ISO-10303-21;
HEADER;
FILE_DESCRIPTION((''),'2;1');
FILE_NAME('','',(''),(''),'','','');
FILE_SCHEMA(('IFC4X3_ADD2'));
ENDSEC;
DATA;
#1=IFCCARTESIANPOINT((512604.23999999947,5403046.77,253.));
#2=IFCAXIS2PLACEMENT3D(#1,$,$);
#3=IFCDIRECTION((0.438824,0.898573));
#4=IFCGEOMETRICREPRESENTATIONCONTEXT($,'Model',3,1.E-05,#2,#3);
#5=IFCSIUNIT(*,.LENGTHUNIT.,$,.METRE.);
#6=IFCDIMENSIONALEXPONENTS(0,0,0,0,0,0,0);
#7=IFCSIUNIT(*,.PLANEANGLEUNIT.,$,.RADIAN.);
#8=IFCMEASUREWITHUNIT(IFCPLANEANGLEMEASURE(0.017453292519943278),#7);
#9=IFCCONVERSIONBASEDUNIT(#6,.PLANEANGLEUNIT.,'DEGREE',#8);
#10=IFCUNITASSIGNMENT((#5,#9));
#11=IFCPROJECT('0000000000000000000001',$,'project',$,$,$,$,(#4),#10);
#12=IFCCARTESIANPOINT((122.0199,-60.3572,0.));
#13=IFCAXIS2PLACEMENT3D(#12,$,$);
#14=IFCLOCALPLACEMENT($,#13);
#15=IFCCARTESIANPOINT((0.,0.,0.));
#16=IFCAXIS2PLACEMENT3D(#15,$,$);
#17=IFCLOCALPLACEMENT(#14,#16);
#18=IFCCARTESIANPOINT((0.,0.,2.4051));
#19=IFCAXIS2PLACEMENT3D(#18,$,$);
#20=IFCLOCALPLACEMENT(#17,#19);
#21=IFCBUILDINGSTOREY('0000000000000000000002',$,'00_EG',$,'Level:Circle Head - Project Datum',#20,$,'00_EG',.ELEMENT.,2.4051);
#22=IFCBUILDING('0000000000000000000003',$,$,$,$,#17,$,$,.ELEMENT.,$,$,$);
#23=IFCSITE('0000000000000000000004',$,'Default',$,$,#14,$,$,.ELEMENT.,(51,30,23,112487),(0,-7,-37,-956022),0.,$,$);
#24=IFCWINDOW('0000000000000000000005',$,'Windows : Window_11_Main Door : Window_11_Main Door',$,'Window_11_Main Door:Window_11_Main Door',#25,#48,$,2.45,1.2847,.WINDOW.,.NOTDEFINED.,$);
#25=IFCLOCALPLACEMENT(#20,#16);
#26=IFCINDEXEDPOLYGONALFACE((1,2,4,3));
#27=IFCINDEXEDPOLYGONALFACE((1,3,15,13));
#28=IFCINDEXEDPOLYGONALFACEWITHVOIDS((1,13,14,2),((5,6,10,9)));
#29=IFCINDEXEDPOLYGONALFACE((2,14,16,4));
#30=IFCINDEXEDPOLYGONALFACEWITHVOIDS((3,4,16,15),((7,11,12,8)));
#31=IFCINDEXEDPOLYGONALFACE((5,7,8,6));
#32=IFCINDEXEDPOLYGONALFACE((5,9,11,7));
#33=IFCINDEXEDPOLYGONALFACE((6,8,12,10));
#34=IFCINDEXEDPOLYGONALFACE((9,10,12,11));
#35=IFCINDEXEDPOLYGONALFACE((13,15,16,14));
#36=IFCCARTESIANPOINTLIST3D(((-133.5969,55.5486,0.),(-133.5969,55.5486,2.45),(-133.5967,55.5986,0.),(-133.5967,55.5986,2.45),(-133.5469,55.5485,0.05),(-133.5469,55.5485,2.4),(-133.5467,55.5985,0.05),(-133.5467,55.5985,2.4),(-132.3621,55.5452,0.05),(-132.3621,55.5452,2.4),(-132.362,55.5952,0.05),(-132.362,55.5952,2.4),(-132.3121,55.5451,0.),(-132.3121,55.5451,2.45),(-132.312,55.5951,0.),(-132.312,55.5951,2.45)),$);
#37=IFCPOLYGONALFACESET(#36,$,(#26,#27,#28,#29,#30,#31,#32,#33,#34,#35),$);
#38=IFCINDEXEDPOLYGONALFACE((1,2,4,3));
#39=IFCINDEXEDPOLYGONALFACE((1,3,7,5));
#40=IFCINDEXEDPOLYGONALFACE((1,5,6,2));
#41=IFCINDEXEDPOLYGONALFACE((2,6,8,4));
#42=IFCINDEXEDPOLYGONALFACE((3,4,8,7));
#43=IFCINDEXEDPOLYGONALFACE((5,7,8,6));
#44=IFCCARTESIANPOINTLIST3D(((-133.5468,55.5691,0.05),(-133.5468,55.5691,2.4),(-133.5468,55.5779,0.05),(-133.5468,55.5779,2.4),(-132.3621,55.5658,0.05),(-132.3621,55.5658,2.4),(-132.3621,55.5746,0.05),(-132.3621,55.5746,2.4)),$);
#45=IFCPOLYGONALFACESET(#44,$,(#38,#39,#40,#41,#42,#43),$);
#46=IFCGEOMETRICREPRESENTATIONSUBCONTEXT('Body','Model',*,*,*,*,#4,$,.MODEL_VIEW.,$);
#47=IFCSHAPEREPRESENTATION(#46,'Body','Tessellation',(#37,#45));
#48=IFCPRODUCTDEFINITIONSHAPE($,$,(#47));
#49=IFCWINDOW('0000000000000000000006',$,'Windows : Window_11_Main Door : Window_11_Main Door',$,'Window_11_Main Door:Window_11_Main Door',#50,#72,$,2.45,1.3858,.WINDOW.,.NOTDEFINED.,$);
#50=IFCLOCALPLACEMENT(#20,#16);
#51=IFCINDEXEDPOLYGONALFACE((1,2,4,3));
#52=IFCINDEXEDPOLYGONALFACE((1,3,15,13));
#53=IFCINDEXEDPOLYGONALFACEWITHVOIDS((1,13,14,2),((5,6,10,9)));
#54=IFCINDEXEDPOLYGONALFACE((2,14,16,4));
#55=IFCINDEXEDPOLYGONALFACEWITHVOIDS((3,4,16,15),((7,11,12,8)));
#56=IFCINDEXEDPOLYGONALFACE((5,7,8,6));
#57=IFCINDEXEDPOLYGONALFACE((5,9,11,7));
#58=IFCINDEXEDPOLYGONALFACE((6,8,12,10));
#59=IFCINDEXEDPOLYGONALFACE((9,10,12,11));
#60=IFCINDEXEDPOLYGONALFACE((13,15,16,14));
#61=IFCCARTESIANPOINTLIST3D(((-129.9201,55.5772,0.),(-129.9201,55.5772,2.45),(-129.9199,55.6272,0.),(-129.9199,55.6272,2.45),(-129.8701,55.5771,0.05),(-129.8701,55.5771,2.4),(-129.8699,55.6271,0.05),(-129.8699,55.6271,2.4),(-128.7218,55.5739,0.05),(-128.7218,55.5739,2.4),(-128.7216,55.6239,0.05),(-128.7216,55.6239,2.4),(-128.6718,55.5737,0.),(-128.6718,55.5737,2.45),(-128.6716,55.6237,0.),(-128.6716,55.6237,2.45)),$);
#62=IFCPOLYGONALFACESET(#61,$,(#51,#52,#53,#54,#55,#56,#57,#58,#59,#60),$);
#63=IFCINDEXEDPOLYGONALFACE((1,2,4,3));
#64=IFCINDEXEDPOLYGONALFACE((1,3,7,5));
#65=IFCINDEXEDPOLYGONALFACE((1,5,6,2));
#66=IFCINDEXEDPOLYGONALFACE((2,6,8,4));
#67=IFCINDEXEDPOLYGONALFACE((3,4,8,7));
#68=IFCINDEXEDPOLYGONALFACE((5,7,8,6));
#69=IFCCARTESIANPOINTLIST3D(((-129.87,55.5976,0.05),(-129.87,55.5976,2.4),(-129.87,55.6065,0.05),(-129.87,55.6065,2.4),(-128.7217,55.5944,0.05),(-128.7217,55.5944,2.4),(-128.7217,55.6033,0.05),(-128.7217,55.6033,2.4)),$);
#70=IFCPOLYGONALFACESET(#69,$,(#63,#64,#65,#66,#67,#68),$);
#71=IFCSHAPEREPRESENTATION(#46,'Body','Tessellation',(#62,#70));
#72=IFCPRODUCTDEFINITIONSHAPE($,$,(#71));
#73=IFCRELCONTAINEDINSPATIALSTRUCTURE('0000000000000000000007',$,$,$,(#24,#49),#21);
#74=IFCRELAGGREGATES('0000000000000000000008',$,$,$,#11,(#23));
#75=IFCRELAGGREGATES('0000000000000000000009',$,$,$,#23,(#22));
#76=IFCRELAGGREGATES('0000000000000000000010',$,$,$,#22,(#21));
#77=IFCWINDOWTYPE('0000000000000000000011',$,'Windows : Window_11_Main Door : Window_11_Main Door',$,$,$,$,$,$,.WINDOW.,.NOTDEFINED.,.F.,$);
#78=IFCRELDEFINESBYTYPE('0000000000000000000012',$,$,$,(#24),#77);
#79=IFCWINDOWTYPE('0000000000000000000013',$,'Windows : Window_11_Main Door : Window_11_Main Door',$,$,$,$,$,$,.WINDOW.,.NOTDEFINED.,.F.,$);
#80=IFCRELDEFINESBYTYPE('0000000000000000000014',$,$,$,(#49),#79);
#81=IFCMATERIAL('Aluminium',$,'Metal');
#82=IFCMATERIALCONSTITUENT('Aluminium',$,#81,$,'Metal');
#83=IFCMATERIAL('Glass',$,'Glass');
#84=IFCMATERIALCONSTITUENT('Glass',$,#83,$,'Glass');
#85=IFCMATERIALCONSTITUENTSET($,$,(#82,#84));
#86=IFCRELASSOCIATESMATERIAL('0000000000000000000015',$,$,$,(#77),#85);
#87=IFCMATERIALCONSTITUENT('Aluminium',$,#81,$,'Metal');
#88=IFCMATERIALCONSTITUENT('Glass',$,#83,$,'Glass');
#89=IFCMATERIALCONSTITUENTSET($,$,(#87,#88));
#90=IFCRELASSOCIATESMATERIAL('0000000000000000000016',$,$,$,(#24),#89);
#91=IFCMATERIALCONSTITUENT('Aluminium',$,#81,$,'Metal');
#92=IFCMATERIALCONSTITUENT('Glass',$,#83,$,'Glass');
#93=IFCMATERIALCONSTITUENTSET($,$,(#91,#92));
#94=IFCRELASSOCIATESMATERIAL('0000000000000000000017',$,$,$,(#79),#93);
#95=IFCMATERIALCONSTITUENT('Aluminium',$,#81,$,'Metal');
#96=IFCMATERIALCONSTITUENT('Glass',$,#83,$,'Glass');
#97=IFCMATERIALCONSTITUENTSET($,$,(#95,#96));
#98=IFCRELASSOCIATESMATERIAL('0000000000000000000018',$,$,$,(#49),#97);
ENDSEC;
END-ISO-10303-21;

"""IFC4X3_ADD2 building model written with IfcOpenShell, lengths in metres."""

from ifc_helpers import new_model, entity, si_unit, converted_unit, direction, frame, frame_2d, origin, origin_2d_with_axis, place, context, subcontext, project, spatial, polyline, rectangle, outline, extrude, source, transform, mapped, material, constituent, constituent_set, type_object, type_shapes, element, save


model = new_model("IFC4X3_ADD2")

# Units and contexts
model_context = context("Model", 3, precision=1e-05, world=frame((512604.23999999947, 5403046.77, 253.0)), true_north=direction((0.438824, 0.898573)))
body_context = subcontext(model_context, "Body", "Model", "MODEL_VIEW")
ifc_project = project(units=[si_unit("LENGTHUNIT", "METRE"), converted_unit("PLANEANGLEUNIT", "DEGREE", entity("IfcPlaneAngleMeasure", 0.017453292519943278), si_unit("PLANEANGLEUNIT", "RADIAN"), dimensions=[0, 0, 0, 0, 0, 0, 0])], contexts=[model_context])

# Site, building, storey
site_placement = place(None, frame((122.0199, -60.3572, 0.0)))
site = spatial("IfcSite", under=ifc_project, at=site_placement, Name="Default", CompositionType="ELEMENT", RefLatitude=(51, 30, 23, 112487), RefLongitude=(0, -7, -37, -956022), RefElevation=0.0)
building_placement = place(site_placement, origin())
building = spatial("IfcBuilding", under=site, at=building_placement, CompositionType="ELEMENT")
storey_placement = place(building_placement, frame((0.0, 0.0, 2.4051)))
storey = spatial("IfcBuildingStorey", under=building, at=storey_placement, Name="00_EG", ObjectType="Level:Circle Head - Project Datum", LongName="00_EG", CompositionType="ELEMENT", Elevation=2.4051)

# Shared definitions
ifc_material_1 = material(Name="Glass", Category="Glass")

# Windows
ifc_material_2 = material(Name="Aluminium", Category="Metal")
ifc_constituent_1 = constituent(ifc_material_2, Name="Aluminium", Category="Metal")
ifc_constituent_2 = constituent(ifc_material_1, Name="Glass", Category="Glass")
ifc_constituent_set_1 = constituent_set(constituents=[ifc_constituent_1, ifc_constituent_2])
ifc_constituent_3 = constituent(ifc_material_2, Name="Aluminium", Category="Metal")
ifc_constituent_4 = constituent(ifc_material_1, Name="Glass", Category="Glass")
ifc_constituent_set_2 = constituent_set(constituents=[ifc_constituent_3, ifc_constituent_4])
window_type_1 = type_object("IfcWindowType", Name="Windows : Window_11_Main Door : Window_11_Main Door", ParameterTakesPrecedence=False, PartitioningType="NOTDEFINED", PredefinedType="WINDOW", material=ifc_constituent_set_2)
shared_shape_1 = source(origin(), body_context, "Body", "SweptSolid", [
    extrude(outline(polyline([(-0.6424, -1.225), (0.6424, -1.225), (0.6424, 1.225), (-0.6424, 1.225), (-0.6424, -1.225)]), holes=[polyline([(-0.5924, 1.175), (0.5924, 1.175), (0.5924, -1.175), (-0.5924, -1.175), (-0.5924, 1.175)])]), frame((0.6424, -0.263, 1.225), z_axis=(0.0, 1.0, 0.0), x_axis=(1.0, 0.0, 0.0)), (0.0, 0.0, 1.0), 0.05),
    extrude(rectangle(XDim=0.0088, YDim=1.1847, at=origin_2d_with_axis()), frame((0.6424, -0.238, 0.05), z_axis=(0.0, 0.0, 1.0), x_axis=(0.0, 1.0, 0.0)), (0.0, 0.0, 1.0), 2.35),
])
type_shapes(window_type_1, [shared_shape_1])
window_1_placement = place(storey_placement, frame((-133.5961, 55.8117, 0.0), z_axis=(0.0, 0.0, 1.0), x_axis=(0.999996, -0.002787, 0.0)))
element("IfcWindow", 1, at=window_1_placement, inside=storey, type_object=window_type_1, material=ifc_constituent_set_1, Name="Windows : Window_11_Main Door : Window_11_Main Door", ObjectType="Window_11_Main Door:Window_11_Main Door", OverallHeight=2.45, OverallWidth=1.2847, PartitioningType="NOTDEFINED", PredefinedType="WINDOW", context=body_context, shape_type="MappedRepresentation", body=[
    mapped(shared_shape_1, transform((0.0, 0.0, 0.0), scale=1.0)),
])
ifc_constituent_5 = constituent(ifc_material_2, Name="Aluminium", Category="Metal")
ifc_constituent_6 = constituent(ifc_material_1, Name="Glass", Category="Glass")
ifc_constituent_set_3 = constituent_set(constituents=[ifc_constituent_5, ifc_constituent_6])
ifc_constituent_7 = constituent(ifc_material_2, Name="Aluminium", Category="Metal")
ifc_constituent_8 = constituent(ifc_material_1, Name="Glass", Category="Glass")
ifc_constituent_set_4 = constituent_set(constituents=[ifc_constituent_7, ifc_constituent_8])
window_type_2 = type_object("IfcWindowType", Name="Windows : Window_11_Main Door : Window_11_Main Door", ParameterTakesPrecedence=False, PartitioningType="NOTDEFINED", PredefinedType="WINDOW", material=ifc_constituent_set_4)
shared_shape_2 = source(origin(), body_context, "Body", "SweptSolid", [
    extrude(outline(polyline([(-0.6242, -1.225), (0.6242, -1.225), (0.6242, 1.225), (-0.6242, 1.225), (-0.6242, -1.225)]), holes=[polyline([(-0.5742, 1.175), (0.5742, 1.175), (0.5742, -1.175), (-0.5742, -1.175), (-0.5742, 1.175)])]), frame((0.6242, -0.2242, 1.225), z_axis=(0.0, 1.0, 0.0), x_axis=(1.0, 0.0, 0.0)), (0.0, 0.0, 1.0), 0.05),
    extrude(rectangle(XDim=0.0088, YDim=1.1483, at=frame_2d((0.0, 0.0), x_axis=(1.0, 0.0))), frame((0.6242, -0.1992, 0.05), z_axis=(0.0, 0.0, 1.0), x_axis=(0.0, 1.0, 0.0)), (0.0, 0.0, 1.0), 2.35),
])
type_shapes(window_type_2, [shared_shape_2])
window_2_placement = place(storey_placement, frame((-129.9195, 55.8014, 0.0), z_axis=(0.0, 0.0, 1.0), x_axis=(0.999996, -0.002787, 0.0)))
element("IfcWindow", 2, at=window_2_placement, inside=storey, type_object=window_type_2, material=ifc_constituent_set_3, Name="Windows : Window_11_Main Door : Window_11_Main Door", ObjectType="Window_11_Main Door:Window_11_Main Door", OverallHeight=2.45, OverallWidth=1.3858, PartitioningType="NOTDEFINED", PredefinedType="WINDOW", context=body_context, shape_type="MappedRepresentation", body=[
    mapped(shared_shape_2, transform((0.0, 0.0, 0.0), scale=1.0)),
])

save(model, "model.ifc")
